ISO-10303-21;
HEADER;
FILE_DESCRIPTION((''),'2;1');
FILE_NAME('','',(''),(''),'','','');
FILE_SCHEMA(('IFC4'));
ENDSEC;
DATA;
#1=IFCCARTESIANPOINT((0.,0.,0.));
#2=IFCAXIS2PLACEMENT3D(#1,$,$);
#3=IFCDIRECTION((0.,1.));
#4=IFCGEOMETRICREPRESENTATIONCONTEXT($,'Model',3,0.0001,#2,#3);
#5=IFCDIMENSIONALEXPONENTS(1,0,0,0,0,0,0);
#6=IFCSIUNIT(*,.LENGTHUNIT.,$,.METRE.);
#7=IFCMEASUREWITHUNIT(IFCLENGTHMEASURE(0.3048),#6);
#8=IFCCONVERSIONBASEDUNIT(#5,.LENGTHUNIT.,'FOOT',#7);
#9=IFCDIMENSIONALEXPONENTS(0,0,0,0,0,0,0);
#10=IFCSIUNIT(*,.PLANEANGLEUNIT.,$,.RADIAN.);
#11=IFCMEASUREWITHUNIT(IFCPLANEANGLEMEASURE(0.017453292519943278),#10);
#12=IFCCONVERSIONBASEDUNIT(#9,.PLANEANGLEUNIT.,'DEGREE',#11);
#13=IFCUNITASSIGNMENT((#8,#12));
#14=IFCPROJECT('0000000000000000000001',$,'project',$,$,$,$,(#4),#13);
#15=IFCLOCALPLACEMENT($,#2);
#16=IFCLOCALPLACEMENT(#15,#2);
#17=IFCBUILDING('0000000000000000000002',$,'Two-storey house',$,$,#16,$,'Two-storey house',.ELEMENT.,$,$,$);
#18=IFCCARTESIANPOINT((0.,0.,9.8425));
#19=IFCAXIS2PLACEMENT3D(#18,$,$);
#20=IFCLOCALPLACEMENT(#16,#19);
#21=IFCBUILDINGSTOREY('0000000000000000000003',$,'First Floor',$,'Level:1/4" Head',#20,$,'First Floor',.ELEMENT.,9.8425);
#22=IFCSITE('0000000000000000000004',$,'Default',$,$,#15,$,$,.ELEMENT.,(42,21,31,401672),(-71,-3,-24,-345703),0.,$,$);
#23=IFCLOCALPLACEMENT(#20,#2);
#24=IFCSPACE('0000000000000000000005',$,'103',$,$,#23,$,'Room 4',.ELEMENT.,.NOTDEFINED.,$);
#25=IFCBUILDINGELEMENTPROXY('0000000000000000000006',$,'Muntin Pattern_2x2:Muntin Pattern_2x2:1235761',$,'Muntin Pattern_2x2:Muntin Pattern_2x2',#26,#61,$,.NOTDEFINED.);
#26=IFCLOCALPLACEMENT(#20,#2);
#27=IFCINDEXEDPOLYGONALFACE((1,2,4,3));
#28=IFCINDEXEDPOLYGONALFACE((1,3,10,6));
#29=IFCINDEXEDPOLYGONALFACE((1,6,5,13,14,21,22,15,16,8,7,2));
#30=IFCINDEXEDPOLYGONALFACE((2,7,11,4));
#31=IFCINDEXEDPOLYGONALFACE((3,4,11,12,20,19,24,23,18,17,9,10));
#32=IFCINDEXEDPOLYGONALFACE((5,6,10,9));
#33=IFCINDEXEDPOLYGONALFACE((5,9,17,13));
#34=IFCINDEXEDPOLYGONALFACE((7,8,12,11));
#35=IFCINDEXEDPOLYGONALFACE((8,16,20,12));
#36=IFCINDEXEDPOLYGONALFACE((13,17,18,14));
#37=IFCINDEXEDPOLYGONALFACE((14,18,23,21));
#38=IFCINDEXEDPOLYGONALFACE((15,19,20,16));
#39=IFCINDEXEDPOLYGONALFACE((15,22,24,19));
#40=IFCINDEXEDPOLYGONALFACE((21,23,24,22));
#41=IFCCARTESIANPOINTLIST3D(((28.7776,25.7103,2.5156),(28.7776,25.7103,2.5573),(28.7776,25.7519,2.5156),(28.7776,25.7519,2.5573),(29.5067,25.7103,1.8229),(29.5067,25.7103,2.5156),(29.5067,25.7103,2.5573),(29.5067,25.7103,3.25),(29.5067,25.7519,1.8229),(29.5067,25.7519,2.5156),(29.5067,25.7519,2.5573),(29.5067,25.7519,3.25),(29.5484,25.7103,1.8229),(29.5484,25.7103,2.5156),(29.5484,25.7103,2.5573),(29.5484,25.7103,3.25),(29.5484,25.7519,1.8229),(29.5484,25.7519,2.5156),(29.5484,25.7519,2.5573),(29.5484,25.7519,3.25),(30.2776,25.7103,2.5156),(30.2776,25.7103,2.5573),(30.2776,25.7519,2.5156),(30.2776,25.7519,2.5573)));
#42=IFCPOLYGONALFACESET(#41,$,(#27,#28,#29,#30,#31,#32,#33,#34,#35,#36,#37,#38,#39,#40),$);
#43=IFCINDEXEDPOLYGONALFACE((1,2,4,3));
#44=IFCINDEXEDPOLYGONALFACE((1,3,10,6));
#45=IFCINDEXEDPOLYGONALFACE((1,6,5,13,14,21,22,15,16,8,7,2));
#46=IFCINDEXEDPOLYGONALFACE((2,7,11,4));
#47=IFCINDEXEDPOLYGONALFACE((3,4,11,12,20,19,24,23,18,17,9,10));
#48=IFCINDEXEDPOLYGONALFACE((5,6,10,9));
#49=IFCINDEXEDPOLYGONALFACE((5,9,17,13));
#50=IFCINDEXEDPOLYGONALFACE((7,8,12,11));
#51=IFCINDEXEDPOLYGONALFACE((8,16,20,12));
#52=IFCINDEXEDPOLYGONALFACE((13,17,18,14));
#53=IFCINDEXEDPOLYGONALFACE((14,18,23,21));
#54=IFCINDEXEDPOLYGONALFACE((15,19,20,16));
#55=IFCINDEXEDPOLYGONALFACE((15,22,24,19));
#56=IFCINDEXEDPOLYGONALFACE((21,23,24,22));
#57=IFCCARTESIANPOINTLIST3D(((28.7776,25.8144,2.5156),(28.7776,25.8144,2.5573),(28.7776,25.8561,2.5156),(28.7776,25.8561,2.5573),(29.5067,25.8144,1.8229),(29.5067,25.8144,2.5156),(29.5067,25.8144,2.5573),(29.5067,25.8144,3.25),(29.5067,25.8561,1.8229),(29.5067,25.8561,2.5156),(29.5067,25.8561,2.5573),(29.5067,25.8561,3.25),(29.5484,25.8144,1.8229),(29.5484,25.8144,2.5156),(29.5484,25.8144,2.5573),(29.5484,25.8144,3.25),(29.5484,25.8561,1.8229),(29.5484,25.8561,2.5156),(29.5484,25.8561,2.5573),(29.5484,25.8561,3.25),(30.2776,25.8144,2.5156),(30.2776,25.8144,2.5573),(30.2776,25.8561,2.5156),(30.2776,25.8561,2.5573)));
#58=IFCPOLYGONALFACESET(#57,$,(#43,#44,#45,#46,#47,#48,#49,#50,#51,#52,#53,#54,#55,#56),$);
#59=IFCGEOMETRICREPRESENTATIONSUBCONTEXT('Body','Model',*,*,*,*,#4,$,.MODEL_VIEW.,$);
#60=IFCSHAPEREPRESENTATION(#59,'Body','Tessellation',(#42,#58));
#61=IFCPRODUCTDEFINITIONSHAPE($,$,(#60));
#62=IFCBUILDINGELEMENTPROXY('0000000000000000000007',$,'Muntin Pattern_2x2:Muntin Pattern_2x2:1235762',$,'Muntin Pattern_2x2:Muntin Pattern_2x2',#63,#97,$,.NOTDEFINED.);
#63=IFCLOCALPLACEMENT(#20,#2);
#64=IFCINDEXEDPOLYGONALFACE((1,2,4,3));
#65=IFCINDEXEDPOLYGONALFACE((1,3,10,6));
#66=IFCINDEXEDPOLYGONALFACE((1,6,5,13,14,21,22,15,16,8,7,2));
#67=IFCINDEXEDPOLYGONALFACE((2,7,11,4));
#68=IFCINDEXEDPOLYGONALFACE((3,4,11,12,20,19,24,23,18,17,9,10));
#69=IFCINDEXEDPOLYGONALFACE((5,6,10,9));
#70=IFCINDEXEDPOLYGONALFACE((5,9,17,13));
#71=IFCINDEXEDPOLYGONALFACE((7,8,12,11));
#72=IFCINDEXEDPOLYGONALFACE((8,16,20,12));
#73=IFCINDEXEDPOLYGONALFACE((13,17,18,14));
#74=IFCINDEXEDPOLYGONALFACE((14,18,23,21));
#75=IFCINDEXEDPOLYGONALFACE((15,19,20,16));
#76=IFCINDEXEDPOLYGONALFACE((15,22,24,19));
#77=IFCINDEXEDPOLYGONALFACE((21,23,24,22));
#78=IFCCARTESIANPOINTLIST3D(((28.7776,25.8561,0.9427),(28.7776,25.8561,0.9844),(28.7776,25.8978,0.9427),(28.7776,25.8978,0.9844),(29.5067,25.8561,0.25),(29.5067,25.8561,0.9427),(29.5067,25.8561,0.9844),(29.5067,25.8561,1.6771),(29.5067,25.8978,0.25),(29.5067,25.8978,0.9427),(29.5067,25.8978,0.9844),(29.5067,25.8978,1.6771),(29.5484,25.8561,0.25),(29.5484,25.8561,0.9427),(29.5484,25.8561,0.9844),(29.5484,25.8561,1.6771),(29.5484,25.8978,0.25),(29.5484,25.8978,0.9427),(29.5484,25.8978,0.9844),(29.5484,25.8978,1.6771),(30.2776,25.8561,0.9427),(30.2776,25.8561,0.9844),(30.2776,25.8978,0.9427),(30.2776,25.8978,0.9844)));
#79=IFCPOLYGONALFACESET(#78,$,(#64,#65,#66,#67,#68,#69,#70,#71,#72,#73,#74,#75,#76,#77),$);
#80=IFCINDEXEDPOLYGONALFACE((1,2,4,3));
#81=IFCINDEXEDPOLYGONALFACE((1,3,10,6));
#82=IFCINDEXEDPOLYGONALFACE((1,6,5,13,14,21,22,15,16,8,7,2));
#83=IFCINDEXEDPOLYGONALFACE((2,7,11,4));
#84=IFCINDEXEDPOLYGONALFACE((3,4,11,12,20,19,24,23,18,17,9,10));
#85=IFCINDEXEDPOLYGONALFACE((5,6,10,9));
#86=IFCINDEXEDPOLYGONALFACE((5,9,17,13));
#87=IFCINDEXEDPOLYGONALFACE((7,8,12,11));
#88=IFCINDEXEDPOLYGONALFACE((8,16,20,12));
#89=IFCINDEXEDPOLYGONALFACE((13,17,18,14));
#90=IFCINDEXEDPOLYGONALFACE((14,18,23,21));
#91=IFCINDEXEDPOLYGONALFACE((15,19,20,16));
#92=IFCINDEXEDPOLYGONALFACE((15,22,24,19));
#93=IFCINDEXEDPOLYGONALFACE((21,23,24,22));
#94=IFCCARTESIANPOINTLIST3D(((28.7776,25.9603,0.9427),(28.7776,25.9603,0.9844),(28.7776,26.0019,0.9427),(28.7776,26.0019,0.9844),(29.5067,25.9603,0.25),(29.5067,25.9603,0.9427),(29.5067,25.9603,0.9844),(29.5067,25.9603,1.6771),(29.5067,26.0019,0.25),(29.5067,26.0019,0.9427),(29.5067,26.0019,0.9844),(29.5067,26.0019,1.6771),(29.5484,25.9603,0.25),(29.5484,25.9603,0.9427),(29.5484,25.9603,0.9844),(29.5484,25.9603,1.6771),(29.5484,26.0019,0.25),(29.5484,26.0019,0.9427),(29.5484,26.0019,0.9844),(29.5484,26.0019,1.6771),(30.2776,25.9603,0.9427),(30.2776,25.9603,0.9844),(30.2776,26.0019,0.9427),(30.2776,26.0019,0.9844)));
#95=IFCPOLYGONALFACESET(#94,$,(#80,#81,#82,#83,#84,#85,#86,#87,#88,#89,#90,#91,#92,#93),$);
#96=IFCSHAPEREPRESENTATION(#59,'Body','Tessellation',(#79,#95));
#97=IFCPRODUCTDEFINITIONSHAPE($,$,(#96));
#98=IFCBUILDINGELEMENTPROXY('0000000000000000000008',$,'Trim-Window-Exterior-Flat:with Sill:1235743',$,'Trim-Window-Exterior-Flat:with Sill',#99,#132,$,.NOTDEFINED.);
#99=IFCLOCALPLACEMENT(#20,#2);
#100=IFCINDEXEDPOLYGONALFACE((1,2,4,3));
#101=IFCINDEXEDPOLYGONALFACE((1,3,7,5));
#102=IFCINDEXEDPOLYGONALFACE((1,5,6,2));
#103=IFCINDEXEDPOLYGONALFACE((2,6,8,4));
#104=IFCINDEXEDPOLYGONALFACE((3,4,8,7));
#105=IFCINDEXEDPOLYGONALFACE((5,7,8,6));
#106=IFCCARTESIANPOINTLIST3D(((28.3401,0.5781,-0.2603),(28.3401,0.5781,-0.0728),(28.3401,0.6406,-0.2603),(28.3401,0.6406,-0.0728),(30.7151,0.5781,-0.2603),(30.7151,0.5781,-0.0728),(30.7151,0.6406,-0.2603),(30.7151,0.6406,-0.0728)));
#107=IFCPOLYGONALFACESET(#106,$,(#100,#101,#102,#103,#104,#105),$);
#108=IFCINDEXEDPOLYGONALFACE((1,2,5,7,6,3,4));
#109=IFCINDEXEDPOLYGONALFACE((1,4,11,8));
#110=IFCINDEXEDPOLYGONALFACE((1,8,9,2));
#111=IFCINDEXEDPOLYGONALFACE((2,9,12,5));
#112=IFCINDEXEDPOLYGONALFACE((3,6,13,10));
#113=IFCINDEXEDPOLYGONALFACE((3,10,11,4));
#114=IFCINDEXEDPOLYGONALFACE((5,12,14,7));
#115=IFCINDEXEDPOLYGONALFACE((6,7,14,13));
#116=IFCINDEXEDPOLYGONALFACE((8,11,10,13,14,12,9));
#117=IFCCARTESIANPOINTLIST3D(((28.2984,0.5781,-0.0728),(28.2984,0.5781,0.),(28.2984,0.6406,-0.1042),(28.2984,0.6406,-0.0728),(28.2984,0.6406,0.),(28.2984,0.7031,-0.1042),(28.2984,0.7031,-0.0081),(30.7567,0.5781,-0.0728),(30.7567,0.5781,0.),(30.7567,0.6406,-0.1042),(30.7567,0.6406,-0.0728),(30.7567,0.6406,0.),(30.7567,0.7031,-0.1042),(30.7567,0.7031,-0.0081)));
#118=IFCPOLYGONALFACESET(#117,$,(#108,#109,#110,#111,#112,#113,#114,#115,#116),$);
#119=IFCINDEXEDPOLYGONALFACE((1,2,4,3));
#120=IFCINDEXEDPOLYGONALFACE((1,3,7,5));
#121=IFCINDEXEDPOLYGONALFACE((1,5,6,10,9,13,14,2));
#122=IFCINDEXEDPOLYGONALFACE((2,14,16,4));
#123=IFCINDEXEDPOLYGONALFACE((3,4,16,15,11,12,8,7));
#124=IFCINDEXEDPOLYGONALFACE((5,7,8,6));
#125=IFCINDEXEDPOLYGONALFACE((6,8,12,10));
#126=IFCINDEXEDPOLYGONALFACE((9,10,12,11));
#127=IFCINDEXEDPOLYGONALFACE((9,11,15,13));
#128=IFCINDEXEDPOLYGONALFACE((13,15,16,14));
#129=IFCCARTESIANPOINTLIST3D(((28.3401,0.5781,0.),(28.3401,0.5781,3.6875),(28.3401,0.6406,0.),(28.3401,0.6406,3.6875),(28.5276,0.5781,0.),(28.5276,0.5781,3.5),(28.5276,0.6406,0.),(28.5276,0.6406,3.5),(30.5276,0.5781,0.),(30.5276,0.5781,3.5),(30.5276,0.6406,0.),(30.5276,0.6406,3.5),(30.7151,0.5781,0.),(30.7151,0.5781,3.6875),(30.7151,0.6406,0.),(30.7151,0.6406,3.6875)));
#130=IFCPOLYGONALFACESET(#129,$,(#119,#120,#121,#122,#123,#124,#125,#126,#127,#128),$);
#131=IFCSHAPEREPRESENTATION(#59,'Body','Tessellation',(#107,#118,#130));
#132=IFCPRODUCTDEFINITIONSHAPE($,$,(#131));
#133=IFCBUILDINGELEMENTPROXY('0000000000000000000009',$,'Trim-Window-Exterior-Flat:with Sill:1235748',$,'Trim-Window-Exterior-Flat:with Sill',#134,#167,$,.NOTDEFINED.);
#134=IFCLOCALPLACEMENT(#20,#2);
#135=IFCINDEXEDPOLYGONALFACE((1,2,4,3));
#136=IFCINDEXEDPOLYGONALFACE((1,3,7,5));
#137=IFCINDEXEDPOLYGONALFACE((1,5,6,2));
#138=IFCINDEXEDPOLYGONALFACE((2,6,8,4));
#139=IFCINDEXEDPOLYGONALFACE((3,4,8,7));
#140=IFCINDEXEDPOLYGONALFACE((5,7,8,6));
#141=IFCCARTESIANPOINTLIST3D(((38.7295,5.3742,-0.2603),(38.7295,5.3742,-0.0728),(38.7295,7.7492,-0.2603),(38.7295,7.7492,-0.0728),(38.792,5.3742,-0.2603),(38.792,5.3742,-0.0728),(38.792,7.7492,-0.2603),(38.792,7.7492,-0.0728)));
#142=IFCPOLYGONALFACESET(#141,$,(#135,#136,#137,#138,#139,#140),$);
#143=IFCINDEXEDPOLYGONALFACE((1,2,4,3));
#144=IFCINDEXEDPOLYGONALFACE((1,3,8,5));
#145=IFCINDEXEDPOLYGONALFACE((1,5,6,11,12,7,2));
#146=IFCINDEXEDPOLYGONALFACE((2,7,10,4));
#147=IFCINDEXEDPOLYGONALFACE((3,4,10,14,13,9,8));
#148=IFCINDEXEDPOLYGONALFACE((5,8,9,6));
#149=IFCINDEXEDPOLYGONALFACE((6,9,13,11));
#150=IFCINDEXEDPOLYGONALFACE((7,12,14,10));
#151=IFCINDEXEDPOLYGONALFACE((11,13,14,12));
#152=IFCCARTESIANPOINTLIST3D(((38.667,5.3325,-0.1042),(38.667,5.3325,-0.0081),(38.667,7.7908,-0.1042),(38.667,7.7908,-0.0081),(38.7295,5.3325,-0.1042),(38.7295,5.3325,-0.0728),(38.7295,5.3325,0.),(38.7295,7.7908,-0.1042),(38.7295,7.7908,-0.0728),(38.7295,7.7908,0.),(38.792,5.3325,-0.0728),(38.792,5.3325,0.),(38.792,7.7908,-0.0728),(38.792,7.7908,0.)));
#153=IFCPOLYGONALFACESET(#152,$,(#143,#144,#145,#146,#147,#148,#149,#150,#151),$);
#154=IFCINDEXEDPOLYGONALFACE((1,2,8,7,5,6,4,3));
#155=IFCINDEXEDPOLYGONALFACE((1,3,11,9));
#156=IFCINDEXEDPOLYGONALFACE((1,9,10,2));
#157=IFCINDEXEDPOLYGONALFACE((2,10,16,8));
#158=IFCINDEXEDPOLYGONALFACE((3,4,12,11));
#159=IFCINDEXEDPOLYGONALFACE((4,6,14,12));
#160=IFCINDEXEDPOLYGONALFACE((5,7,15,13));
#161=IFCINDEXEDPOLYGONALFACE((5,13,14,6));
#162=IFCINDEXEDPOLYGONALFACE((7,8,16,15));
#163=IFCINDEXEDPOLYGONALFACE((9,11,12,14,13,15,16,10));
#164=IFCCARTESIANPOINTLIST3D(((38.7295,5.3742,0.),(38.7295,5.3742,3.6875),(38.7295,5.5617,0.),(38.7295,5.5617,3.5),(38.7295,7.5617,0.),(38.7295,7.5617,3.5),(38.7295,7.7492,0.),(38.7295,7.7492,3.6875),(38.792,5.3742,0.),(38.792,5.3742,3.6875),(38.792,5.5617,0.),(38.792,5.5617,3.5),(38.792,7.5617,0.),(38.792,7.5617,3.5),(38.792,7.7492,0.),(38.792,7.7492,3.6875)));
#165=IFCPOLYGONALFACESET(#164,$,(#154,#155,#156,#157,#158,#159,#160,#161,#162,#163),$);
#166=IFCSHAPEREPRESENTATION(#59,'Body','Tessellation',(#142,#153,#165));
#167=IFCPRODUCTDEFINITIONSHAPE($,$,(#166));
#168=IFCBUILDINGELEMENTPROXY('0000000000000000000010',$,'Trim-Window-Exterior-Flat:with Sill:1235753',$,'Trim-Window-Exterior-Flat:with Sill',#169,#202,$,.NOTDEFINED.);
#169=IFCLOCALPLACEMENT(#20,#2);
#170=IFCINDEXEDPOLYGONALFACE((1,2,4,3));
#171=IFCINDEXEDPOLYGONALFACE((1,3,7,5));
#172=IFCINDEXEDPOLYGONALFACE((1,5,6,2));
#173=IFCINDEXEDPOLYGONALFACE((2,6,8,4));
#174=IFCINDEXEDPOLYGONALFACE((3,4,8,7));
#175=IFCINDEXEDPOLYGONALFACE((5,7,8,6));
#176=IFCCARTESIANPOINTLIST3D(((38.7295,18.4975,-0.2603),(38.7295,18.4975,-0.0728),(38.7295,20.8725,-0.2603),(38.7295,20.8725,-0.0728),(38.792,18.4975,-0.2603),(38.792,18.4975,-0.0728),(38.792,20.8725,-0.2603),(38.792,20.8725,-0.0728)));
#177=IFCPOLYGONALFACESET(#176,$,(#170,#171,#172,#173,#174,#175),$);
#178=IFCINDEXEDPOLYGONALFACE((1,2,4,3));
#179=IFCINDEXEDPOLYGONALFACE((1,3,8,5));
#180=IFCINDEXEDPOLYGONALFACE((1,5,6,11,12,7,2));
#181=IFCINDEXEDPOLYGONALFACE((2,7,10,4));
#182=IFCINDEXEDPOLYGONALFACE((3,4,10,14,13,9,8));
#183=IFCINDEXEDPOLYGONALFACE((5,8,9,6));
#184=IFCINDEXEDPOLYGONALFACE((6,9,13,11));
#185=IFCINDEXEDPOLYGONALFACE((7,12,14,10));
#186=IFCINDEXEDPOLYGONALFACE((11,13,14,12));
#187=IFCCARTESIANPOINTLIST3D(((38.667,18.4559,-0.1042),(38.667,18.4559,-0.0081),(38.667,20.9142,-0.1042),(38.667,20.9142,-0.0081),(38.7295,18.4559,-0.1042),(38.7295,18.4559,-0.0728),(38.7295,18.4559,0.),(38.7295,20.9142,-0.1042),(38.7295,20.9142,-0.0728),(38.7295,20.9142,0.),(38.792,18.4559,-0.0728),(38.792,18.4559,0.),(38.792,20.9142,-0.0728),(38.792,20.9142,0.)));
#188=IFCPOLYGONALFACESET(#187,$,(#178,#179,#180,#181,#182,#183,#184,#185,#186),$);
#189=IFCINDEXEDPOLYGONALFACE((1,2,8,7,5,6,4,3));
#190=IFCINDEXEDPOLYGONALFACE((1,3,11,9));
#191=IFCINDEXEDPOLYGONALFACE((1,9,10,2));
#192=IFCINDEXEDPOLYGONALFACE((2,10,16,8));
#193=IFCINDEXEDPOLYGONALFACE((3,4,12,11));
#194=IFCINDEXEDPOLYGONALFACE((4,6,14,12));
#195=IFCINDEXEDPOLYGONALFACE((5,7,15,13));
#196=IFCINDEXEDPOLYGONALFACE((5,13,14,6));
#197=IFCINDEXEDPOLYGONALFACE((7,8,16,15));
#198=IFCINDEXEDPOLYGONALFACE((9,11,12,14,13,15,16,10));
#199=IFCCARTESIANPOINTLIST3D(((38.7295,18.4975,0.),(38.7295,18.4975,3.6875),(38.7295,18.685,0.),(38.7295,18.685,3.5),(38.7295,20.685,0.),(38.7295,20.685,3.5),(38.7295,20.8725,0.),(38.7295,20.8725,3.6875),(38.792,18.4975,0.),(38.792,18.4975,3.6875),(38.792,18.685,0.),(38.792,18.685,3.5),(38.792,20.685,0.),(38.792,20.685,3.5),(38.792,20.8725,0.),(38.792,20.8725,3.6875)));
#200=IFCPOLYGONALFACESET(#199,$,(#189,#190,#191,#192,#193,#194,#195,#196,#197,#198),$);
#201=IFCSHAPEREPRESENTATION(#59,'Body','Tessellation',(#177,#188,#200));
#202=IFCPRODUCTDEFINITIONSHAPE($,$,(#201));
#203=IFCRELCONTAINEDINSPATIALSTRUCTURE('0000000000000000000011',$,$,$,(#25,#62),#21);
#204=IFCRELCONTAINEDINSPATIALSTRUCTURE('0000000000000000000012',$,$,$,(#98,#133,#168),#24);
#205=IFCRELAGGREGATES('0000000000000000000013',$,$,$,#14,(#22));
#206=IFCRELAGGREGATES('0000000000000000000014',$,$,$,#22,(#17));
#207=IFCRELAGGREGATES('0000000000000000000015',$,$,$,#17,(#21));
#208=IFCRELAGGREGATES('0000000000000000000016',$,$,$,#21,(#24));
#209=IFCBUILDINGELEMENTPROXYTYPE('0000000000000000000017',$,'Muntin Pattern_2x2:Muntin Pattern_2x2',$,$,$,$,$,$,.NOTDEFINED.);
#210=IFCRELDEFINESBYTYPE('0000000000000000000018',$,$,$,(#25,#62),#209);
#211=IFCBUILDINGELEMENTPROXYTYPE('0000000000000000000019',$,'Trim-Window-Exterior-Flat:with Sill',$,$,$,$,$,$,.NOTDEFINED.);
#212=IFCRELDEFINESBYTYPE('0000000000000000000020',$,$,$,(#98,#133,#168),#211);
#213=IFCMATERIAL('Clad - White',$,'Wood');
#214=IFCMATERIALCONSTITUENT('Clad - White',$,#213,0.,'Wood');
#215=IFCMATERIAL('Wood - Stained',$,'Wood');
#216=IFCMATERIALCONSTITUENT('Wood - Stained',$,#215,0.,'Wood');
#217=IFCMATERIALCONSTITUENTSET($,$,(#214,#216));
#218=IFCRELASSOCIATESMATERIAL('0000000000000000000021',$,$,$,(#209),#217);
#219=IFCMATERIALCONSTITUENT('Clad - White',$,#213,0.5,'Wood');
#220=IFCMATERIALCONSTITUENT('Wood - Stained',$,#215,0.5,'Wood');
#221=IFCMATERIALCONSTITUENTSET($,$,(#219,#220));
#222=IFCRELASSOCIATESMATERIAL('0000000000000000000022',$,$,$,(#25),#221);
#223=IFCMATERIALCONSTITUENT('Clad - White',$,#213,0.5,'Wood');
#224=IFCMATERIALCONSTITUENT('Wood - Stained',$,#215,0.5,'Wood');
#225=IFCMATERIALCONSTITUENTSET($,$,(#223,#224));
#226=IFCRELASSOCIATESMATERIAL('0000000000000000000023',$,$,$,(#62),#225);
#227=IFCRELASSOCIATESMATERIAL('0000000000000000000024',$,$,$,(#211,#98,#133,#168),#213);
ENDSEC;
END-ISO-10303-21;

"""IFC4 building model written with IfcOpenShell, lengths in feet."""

from ifc_helpers import new_model, entity, si_unit, converted_unit, direction, frame, origin, place, context, subcontext, project, spatial, indexed_curve, outline, extrude, source, transform, mapped, material, constituent, constituent_set, type_object, type_shapes, element, save


model = new_model("IFC4")

# Units and contexts
model_context = context("Model", 3, precision=0.0001, world=origin(), true_north=direction((0.0, 1.0)))
body_context = subcontext(model_context, "Body", "Model", "MODEL_VIEW")
ifc_project = project(units=[converted_unit("LENGTHUNIT", "FOOT", entity("IfcLengthMeasure", 0.3048), si_unit("LENGTHUNIT", "METRE"), dimensions=[1, 0, 0, 0, 0, 0, 0]), converted_unit("PLANEANGLEUNIT", "DEGREE", entity("IfcPlaneAngleMeasure", 0.017453292519943278), si_unit("PLANEANGLEUNIT", "RADIAN"), dimensions=[0, 0, 0, 0, 0, 0, 0])], contexts=[model_context])

# Site, building, storey
site_placement = place(None, origin())
site = spatial("IfcSite", under=ifc_project, at=site_placement, Name="Default", CompositionType="ELEMENT", RefLatitude=(42, 21, 31, 401672), RefLongitude=(-71, -3, -24, -345703), RefElevation=0.0)
building_placement = place(site_placement, origin())
building = spatial("IfcBuilding", under=site, at=building_placement, Name="Two-storey house", LongName="Two-storey house", CompositionType="ELEMENT")
storey_placement = place(building_placement, frame((0.0, 0.0, 9.8425)))
storey = spatial("IfcBuildingStorey", under=building, at=storey_placement, Name="First Floor", ObjectType="Level:1/4\" Head", LongName="First Floor", CompositionType="ELEMENT", Elevation=9.8425)

# Shared definitions
ifc_material_1 = material(Name="Wood - Stained", Category="Wood")

# Building element proxies
ifc_material_2 = material(Name="Clad - White", Category="Wood")
ifc_constituent_1 = constituent(ifc_material_2, Name="Clad - White", Category="Wood", fraction=0.0)
ifc_constituent_2 = constituent(ifc_material_1, Name="Wood - Stained", Category="Wood", fraction=0.0)
ifc_constituent_set_1 = constituent_set(constituents=[ifc_constituent_1, ifc_constituent_2])
building_element_proxy_type_1 = type_object("IfcBuildingElementProxyType", Name="Muntin Pattern_2x2:Muntin Pattern_2x2", PredefinedType="NOTDEFINED", material=ifc_constituent_set_1)
shared_shape_1 = source(origin(), body_context, "Body", "SweptSolid", [
    extrude(outline(indexed_curve([(0.0208, -0.0208), (0.7135, -0.0208), (0.7135, 0.0208), (0.0208, 0.0208), (0.0208, 0.75), (-0.0208, 0.75), (-0.0208, 0.0208), (-0.7135, 0.0208), (-0.7135, -0.0208), (-0.0208, -0.0208), (-0.0208, -0.75), (0.0208, -0.75), (0.0208, -0.0208)], self_intersect=False)), frame((0.0, 0.0312, 0.7135), z_axis=(0.0, 1.0, 0.0), x_axis=(0.0, 0.0, 1.0)), (0.0, 0.0, 1.0), 0.0417),
    extrude(outline(indexed_curve([(0.0208, -0.0208), (0.7135, -0.0208), (0.7135, 0.0208), (0.0208, 0.0208), (0.0208, 0.75), (-0.0208, 0.75), (-0.0208, 0.0208), (-0.7135, 0.0208), (-0.7135, -0.0208), (-0.0208, -0.0208), (-0.0208, -0.75), (0.0208, -0.75), (0.0208, -0.0208)], self_intersect=False)), frame((0.0, -0.0729, 0.7135), z_axis=(0.0, 1.0, 0.0), x_axis=(0.0, 0.0, 1.0)), (0.0, 0.0, 1.0), 0.0417),
])
type_shapes(building_element_proxy_type_1, [shared_shape_1])
ifc_constituent_3 = constituent(ifc_material_2, Name="Clad - White", Category="Wood", fraction=0.5)
ifc_constituent_4 = constituent(ifc_material_1, Name="Wood - Stained", Category="Wood", fraction=0.5)
ifc_constituent_set_2 = constituent_set(constituents=[ifc_constituent_3, ifc_constituent_4])
proxy_1_placement = place(storey_placement, frame((29.5276, 25.7832, 1.8229), z_axis=(0.0, 0.0, 1.0), x_axis=(-1.0, 0.0, 0.0)))
element("IfcBuildingElementProxy", 1, at=proxy_1_placement, inside=storey, type_object=building_element_proxy_type_1, material=ifc_constituent_set_2, Name="Muntin Pattern_2x2:Muntin Pattern_2x2:1235761", ObjectType="Muntin Pattern_2x2:Muntin Pattern_2x2", PredefinedType="NOTDEFINED", context=body_context, shape_type="MappedRepresentation", body=[
    mapped(shared_shape_1, transform((0.0, 0.0, 0.0), scale=1.0)),
])
ifc_constituent_5 = constituent(ifc_material_2, Name="Clad - White", Category="Wood", fraction=0.5)
ifc_constituent_6 = constituent(ifc_material_1, Name="Wood - Stained", Category="Wood", fraction=0.5)
ifc_constituent_set_3 = constituent_set(constituents=[ifc_constituent_5, ifc_constituent_6])
proxy_2_placement = place(storey_placement, frame((29.5276, 25.929, 0.25), z_axis=(0.0, 0.0, 1.0), x_axis=(-1.0, 0.0, 0.0)))
element("IfcBuildingElementProxy", 2, at=proxy_2_placement, inside=storey, type_object=building_element_proxy_type_1, material=ifc_constituent_set_3, Name="Muntin Pattern_2x2:Muntin Pattern_2x2:1235762", ObjectType="Muntin Pattern_2x2:Muntin Pattern_2x2", PredefinedType="NOTDEFINED", context=body_context, shape_type="MappedRepresentation", body=[
    mapped(shared_shape_1, transform((0.0, 0.0, 0.0), scale=1.0)),
])

# Shared definitions
space_placement = place(storey_placement, origin())
space = spatial("IfcSpace", under=storey, at=space_placement, Name="103", LongName="Room 4", CompositionType="ELEMENT", PredefinedType="NOTDEFINED")

# Building element proxies
building_element_proxy_type_2 = type_object("IfcBuildingElementProxyType", Name="Trim-Window-Exterior-Flat:with Sill", PredefinedType="NOTDEFINED", material=ifc_material_2)
shared_shape_2 = source(origin(), body_context, "Body", "SweptSolid", [
    extrude(outline(indexed_curve([(-1.1875, -0.0938), (1.1875, -0.0938), (1.1875, 0.0938), (-1.1875, 0.0938), (-1.1875, -0.0938)], self_intersect=False)), frame((0.0, -3.6665, 0.0), z_axis=(0.0, 0.0, 1.0), x_axis=(-1.0, 0.0, 0.0)), (0.0, 0.0, 1.0), 0.0625),
    extrude(outline(indexed_curve([(-0.0625, -0.0525), (0.0, -0.0525), (0.0, -0.0211), (0.0625, -0.0211), (0.0625, 0.0517), (0.0, 0.0517), (-0.0625, 0.0436), (-0.0625, -0.0525)], self_intersect=False)), frame((-1.2292, -3.5517, 0.0625), z_axis=(1.0, 0.0, 0.0), x_axis=(0.0, 0.0, -1.0)), (0.0, 0.0, 1.0), 2.4583),
    extrude(outline(indexed_curve([(-1.8906, -1.1875), (1.7969, -1.1875), (1.7969, -1.0), (-1.7031, -1.0), (-1.7031, 1.0), (1.7969, 1.0), (1.7969, 1.1875), (-1.8906, 1.1875), (-1.8906, -1.1875)], self_intersect=False)), frame((0.0, -1.7031, 0.0), z_axis=(0.0, 0.0, 1.0), x_axis=(0.0, -1.0, 0.0)), (0.0, 0.0, 1.0), 0.0625),
])
type_shapes(building_element_proxy_type_2, [shared_shape_2])
for number, where, z_axis, x_axis, name in (
    (3, (29.5276, 0.5781, 3.5), (0.0, 1.0, 0.0), (-1.0, 0.0, 0.0), "Trim-Window-Exterior-Flat:with Sill:1235743"),
    (4, (38.792, 6.5617, 3.5), (-1.0, 0.0, 0.0), (0.0, -1.0, 0.0), "Trim-Window-Exterior-Flat:with Sill:1235748"),
    (5, (38.792, 19.685, 3.5), (-1.0, 0.0, 0.0), (0.0, -1.0, 0.0), "Trim-Window-Exterior-Flat:with Sill:1235753"),
):
    element("IfcBuildingElementProxy", number, at=place(space_placement, frame(where, z_axis=z_axis, x_axis=x_axis)), inside=space, type_object=building_element_proxy_type_2, material=ifc_material_2, Name=name, ObjectType="Trim-Window-Exterior-Flat:with Sill", PredefinedType="NOTDEFINED", context=body_context, shape_type="MappedRepresentation", body=[
        mapped(shared_shape_2, transform((0.0, 0.0, 0.0), scale=1.0)),
    ])

save(model, "model.ifc")
